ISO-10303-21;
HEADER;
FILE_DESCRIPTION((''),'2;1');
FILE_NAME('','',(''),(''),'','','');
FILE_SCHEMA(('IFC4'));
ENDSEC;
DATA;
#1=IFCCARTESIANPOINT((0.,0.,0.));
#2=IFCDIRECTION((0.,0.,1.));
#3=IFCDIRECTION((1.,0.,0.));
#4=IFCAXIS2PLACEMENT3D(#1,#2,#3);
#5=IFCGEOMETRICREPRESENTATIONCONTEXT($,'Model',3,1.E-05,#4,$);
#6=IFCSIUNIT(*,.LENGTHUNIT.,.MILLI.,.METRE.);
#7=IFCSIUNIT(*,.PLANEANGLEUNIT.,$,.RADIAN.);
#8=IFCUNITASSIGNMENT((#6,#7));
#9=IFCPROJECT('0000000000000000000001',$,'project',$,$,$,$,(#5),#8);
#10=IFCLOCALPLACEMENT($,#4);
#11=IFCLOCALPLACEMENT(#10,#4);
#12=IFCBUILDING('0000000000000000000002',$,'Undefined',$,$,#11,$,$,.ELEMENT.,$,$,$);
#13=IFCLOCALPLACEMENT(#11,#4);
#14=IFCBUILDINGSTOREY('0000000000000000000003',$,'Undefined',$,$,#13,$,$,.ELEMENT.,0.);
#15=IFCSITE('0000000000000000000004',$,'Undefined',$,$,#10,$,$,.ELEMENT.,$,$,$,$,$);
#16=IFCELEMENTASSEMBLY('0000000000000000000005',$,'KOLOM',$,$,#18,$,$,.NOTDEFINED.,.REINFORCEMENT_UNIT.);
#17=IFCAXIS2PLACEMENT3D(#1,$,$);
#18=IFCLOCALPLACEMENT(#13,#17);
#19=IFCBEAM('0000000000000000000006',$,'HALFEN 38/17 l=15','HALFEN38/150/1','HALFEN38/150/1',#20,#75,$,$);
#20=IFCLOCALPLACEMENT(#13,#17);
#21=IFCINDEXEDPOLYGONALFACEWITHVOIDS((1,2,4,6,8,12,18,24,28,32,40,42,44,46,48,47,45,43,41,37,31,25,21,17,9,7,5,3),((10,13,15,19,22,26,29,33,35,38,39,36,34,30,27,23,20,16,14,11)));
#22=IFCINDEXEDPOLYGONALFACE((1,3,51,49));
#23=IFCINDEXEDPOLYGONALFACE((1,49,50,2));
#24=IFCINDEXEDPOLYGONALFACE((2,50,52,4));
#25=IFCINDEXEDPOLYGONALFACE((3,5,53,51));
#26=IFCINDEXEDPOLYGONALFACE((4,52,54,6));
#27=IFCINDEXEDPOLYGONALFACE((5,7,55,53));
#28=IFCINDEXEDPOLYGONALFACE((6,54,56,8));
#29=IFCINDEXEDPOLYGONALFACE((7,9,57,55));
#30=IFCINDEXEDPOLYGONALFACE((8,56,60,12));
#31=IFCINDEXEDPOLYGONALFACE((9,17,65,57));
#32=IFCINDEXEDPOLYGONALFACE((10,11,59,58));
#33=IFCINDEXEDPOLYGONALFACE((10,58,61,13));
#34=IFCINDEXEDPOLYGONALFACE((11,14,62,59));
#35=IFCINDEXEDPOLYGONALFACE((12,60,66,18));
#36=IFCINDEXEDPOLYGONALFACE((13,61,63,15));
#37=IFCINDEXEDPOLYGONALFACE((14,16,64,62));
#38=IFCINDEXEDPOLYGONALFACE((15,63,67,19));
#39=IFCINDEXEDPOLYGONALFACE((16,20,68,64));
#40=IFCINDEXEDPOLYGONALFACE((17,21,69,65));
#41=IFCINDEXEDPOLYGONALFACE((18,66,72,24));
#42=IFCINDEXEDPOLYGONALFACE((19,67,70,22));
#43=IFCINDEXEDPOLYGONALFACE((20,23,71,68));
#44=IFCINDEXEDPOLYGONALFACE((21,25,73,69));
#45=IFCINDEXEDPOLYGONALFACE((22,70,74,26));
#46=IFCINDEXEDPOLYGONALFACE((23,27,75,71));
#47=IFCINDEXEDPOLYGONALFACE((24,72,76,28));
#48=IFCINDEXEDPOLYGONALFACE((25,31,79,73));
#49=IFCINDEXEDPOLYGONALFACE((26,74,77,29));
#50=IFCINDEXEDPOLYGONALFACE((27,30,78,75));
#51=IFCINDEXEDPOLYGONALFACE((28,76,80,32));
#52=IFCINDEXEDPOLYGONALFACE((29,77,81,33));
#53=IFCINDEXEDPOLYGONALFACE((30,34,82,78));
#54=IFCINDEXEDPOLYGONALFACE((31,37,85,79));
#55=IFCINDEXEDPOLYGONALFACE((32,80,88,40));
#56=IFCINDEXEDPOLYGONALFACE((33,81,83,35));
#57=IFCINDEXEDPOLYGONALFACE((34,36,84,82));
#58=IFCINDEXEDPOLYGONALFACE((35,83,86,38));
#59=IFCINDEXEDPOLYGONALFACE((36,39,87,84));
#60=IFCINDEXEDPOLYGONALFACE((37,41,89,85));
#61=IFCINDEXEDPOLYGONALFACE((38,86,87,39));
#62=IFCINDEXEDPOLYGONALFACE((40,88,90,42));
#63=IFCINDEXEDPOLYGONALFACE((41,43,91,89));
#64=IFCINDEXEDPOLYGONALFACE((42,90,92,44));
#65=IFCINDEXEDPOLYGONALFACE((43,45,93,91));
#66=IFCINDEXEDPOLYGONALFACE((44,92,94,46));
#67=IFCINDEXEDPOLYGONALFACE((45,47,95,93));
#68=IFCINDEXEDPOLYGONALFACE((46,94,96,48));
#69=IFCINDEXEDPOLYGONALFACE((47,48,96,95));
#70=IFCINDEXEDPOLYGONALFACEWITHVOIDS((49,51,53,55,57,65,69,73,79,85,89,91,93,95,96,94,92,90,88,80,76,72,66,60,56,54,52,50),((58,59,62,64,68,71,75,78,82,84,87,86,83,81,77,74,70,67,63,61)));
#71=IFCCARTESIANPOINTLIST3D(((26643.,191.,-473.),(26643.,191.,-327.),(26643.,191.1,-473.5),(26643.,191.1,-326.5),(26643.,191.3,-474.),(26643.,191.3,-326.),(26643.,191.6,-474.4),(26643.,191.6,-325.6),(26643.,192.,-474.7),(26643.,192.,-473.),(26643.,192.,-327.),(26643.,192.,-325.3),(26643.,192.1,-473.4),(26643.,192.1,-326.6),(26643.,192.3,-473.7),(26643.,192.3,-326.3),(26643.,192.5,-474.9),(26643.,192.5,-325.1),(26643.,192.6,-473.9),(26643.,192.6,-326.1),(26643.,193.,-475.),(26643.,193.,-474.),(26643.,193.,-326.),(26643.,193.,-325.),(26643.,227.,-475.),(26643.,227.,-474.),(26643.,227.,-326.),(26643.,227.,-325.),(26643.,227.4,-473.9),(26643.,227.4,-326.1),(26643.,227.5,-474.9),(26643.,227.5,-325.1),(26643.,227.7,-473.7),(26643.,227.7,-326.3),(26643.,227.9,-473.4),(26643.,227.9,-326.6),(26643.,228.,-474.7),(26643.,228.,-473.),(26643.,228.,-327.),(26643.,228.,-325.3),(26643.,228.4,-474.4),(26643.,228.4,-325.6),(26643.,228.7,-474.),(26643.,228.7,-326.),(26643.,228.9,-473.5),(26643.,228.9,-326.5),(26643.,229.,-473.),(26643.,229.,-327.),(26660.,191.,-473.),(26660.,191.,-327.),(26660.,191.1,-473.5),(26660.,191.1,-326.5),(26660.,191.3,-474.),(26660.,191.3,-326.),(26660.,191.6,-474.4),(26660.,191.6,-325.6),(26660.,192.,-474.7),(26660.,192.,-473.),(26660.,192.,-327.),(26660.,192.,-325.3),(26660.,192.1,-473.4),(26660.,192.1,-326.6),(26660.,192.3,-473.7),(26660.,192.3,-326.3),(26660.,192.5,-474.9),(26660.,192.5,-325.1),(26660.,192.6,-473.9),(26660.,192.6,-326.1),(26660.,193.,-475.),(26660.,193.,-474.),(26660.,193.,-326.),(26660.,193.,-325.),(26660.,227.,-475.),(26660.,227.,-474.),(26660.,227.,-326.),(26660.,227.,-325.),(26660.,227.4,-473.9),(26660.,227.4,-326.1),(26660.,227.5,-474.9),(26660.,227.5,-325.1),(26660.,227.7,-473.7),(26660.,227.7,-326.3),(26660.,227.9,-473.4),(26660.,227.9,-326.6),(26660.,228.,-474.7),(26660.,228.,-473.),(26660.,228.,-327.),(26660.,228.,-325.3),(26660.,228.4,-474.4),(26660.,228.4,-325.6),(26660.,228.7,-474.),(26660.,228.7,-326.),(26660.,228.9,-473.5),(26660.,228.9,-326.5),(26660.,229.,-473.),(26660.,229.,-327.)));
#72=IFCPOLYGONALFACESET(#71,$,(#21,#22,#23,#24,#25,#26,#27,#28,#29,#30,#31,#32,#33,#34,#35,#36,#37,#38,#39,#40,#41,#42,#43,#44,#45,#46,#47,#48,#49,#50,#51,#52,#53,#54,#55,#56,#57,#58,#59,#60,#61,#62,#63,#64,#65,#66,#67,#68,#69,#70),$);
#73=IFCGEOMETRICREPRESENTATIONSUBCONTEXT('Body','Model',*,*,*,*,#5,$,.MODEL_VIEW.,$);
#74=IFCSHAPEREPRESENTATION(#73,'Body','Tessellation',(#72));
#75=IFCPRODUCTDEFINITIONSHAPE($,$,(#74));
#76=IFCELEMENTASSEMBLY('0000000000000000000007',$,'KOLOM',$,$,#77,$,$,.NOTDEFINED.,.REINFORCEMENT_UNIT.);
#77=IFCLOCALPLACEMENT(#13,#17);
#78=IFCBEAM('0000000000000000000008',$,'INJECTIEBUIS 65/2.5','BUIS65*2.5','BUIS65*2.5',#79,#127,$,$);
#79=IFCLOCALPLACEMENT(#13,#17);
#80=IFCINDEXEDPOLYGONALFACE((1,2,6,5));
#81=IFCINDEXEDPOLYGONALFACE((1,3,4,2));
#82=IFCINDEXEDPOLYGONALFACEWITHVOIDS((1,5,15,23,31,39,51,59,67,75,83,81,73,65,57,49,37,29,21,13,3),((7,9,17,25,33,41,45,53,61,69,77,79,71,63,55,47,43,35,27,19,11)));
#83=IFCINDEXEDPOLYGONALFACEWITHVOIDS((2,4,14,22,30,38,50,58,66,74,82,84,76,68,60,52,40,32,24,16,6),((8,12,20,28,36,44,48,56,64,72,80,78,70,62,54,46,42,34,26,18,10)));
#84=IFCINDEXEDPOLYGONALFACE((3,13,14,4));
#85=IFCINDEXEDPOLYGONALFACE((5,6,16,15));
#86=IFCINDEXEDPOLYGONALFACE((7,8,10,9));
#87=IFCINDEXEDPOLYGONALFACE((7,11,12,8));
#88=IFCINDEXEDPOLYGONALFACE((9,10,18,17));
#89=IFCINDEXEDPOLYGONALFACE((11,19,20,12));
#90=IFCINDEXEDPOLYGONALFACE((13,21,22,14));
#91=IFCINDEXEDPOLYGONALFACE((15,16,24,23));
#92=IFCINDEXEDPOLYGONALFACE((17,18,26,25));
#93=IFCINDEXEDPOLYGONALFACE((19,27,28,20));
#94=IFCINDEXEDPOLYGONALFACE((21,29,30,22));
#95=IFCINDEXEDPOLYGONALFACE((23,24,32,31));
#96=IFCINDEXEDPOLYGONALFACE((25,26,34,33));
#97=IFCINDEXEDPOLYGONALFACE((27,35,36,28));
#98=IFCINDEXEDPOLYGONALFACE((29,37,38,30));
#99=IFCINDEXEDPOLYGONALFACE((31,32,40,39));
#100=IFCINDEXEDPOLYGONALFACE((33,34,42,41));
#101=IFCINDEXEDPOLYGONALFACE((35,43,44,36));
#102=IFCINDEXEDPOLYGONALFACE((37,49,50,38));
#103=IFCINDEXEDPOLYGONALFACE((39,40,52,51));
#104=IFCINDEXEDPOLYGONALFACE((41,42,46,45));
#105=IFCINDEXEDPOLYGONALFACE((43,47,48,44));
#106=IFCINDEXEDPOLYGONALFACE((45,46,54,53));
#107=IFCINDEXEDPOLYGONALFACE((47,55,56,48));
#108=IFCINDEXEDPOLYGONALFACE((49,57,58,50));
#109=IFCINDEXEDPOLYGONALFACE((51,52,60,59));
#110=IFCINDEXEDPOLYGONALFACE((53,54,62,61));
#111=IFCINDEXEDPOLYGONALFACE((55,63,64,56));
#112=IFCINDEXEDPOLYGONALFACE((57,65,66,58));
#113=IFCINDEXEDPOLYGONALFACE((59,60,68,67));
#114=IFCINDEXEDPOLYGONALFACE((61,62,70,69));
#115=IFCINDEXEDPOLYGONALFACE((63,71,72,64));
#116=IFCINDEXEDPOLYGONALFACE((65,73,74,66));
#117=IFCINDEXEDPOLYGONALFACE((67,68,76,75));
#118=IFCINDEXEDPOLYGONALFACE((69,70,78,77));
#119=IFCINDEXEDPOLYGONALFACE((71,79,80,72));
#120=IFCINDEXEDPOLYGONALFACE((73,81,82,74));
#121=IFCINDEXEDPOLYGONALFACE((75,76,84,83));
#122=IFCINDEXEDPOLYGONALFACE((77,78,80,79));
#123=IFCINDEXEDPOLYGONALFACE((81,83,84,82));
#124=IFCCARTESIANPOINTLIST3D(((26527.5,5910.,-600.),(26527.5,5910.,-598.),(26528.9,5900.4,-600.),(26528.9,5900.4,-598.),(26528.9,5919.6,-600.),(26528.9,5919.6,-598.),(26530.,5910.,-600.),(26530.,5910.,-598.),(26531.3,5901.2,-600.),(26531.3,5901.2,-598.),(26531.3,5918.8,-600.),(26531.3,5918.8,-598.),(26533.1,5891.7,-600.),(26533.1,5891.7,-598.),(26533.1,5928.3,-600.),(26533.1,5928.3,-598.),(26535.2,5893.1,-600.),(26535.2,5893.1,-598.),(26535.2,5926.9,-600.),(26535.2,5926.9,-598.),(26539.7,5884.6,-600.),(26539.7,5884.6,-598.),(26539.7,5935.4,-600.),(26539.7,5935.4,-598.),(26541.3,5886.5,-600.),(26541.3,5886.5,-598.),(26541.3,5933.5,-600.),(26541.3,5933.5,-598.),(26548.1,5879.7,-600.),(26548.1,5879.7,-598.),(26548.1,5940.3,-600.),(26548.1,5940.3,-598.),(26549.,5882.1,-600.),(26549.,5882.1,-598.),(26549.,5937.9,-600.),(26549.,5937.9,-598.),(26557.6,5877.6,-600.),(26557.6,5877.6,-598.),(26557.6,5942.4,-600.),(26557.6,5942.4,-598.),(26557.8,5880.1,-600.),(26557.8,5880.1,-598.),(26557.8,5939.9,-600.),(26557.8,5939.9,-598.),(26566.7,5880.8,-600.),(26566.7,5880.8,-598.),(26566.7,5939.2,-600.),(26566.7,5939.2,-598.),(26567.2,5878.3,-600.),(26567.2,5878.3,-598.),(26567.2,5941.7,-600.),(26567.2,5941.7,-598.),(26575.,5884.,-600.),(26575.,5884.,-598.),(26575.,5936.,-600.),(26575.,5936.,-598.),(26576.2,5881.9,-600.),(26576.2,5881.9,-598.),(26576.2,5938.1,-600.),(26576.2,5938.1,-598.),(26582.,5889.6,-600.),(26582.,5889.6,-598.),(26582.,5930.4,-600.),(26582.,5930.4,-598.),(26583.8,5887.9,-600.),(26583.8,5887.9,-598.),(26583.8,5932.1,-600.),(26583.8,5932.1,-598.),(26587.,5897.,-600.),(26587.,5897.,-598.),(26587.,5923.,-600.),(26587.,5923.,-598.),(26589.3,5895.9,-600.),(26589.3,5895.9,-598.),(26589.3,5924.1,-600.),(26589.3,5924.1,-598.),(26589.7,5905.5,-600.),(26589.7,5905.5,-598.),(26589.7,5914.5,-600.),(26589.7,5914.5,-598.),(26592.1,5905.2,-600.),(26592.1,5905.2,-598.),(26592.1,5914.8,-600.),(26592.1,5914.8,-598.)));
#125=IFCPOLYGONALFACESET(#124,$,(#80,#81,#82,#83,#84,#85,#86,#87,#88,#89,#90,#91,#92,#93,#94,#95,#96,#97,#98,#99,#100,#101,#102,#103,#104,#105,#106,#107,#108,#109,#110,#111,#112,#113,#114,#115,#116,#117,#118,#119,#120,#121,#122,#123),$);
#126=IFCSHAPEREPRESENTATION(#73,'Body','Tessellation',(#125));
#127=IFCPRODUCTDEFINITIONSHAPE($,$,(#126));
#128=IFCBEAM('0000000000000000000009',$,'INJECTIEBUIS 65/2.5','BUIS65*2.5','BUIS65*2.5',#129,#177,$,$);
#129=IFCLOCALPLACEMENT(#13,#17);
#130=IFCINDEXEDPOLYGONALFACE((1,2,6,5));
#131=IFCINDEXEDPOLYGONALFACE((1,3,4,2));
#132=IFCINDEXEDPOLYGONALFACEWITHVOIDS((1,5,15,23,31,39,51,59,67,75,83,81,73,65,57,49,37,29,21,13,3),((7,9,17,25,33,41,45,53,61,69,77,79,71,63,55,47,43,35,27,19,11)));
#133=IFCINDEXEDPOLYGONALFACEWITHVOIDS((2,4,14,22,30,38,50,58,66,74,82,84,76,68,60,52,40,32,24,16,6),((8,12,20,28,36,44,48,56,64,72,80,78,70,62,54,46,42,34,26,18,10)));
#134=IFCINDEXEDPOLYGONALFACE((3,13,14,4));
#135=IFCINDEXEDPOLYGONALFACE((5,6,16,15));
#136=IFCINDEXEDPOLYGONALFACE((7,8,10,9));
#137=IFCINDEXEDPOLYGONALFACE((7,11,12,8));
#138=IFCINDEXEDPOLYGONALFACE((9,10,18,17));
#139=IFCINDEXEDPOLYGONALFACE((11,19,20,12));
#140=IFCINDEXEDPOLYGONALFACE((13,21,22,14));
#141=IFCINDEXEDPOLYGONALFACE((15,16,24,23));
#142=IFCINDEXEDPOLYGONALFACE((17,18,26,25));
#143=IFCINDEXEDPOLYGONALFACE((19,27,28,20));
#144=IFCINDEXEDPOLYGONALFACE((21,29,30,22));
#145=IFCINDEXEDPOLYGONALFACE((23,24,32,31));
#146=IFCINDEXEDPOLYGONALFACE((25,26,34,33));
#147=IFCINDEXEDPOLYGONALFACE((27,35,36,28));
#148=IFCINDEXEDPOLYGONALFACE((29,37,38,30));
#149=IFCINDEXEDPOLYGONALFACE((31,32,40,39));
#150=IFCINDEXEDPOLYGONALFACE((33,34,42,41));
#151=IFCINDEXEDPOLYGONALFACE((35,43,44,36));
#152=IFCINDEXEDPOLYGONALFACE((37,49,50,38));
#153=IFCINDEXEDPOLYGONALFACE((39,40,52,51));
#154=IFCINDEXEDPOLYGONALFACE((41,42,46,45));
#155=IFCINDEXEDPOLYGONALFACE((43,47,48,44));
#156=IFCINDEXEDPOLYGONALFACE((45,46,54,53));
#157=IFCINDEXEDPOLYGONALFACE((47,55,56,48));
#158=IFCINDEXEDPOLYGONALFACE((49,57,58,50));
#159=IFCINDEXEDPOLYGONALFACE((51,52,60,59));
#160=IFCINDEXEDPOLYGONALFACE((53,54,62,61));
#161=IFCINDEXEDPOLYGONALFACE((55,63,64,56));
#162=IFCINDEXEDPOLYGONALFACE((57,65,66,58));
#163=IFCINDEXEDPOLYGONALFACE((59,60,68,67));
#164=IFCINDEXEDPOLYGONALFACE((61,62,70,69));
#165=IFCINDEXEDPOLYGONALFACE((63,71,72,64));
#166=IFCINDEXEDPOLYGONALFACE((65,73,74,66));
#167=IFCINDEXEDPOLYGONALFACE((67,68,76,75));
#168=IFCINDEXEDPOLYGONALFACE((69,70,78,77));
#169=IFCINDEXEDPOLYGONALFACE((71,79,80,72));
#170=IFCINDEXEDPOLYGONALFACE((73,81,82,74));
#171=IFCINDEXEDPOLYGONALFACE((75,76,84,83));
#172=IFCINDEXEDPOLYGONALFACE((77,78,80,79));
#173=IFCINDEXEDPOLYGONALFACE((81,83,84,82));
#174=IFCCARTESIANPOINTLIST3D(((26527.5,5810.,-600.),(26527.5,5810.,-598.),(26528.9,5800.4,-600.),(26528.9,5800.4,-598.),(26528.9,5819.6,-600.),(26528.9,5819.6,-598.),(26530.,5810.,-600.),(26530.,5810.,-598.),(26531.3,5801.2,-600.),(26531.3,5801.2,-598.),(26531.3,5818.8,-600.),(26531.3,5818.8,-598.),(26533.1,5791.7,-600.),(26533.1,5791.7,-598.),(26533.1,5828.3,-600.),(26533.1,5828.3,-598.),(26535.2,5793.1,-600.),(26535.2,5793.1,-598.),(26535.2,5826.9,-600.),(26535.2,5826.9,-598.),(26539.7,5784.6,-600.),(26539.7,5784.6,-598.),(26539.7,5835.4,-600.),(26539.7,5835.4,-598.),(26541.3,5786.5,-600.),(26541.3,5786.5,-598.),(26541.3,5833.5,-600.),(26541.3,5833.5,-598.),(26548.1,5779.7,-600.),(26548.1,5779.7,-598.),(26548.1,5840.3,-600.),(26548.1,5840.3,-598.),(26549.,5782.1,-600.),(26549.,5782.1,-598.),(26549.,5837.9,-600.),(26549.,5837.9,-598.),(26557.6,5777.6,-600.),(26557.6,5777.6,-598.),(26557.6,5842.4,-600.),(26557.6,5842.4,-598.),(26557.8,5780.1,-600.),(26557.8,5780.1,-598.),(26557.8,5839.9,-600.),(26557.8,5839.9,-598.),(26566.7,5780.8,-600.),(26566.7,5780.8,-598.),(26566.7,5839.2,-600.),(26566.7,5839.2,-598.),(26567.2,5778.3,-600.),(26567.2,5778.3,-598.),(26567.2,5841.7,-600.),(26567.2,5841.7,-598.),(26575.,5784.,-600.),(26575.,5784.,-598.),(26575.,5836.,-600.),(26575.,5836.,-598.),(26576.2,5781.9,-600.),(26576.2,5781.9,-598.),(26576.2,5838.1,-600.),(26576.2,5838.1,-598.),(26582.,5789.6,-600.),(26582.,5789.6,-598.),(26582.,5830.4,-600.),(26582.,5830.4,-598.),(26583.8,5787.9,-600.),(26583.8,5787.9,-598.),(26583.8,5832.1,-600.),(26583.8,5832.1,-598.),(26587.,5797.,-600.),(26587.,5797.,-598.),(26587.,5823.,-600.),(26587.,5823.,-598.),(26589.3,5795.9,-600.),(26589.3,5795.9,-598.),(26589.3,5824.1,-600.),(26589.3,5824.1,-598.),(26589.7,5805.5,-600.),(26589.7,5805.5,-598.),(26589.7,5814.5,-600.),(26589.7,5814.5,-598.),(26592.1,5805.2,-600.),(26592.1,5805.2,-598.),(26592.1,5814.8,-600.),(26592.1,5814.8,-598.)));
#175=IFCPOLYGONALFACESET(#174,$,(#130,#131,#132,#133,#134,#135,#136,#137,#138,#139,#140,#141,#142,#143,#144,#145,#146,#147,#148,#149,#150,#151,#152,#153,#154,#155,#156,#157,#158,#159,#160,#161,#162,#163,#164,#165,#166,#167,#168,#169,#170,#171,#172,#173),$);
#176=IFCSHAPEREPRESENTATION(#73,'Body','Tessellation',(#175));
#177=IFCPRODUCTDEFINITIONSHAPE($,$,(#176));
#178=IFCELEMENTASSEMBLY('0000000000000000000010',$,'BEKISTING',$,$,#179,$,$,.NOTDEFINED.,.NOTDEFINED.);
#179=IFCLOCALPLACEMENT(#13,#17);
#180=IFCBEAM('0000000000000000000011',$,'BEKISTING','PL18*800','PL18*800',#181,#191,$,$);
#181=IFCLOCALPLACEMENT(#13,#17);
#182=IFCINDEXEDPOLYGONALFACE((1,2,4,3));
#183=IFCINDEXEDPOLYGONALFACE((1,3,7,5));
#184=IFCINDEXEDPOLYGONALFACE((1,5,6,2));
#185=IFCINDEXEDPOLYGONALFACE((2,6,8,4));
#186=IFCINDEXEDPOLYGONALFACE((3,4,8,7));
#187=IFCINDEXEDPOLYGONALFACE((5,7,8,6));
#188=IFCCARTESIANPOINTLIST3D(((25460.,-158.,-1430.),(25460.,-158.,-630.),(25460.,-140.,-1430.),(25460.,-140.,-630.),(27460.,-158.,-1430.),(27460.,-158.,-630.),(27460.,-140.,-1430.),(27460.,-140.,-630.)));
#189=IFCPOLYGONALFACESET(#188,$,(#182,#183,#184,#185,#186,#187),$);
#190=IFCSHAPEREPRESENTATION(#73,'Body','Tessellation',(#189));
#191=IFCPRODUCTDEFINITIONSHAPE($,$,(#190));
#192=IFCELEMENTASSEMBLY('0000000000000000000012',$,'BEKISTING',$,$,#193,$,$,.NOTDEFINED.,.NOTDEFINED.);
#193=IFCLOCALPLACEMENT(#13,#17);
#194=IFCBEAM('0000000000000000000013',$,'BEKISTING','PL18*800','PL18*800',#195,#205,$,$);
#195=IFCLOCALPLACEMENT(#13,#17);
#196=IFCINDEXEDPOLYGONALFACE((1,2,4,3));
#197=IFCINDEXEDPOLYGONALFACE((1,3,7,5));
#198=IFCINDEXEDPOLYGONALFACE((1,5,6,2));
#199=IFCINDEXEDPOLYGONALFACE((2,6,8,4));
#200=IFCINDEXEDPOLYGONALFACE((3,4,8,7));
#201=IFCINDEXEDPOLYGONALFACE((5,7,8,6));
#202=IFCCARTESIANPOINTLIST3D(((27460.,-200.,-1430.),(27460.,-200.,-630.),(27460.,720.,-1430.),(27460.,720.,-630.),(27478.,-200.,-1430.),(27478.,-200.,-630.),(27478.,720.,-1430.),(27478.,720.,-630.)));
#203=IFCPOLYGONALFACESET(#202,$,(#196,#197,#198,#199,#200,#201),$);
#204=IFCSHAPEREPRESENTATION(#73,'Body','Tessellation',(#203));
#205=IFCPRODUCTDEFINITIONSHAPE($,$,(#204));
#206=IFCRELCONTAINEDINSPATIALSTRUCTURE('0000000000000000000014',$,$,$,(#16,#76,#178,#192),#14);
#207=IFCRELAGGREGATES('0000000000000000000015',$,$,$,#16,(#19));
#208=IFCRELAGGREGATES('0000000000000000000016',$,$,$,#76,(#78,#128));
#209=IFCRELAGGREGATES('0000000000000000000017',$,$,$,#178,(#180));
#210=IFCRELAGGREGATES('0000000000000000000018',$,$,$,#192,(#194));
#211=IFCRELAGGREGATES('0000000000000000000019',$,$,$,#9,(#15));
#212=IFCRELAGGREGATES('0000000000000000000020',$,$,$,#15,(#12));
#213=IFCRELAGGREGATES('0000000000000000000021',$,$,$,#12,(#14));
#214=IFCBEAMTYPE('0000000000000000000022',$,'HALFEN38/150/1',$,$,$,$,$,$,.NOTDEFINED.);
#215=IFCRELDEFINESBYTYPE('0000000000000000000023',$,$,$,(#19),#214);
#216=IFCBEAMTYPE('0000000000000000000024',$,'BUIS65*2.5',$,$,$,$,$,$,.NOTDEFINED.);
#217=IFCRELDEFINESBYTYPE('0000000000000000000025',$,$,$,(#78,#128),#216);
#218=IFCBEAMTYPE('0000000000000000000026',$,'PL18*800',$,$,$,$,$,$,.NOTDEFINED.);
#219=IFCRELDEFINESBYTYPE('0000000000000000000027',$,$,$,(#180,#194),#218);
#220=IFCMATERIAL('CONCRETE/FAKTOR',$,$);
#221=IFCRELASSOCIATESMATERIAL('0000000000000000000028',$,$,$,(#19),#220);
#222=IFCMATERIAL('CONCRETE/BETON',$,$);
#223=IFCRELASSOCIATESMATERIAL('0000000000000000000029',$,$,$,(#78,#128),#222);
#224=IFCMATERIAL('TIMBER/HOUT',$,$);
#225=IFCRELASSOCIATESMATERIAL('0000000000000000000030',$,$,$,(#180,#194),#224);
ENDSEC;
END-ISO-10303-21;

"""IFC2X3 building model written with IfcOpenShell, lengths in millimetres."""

from ifc_helpers import new_model, si_unit, frame, frame_2d, origin_with_axes, place, context, subcontext, project, spatial, rectangle, hollow_rectangle, hollow_circle, extrude, material, type_object, element, aggregate, save


model = new_model("IFC2X3")

# Units and contexts
model_context = context("Model", 3, precision=1e-05, world=origin_with_axes())
body_context = subcontext(model_context, "Body", "Model", "MODEL_VIEW")
ifc_project = project(units=[si_unit("LENGTHUNIT", "METRE", prefix="MILLI"), si_unit("PLANEANGLEUNIT", "RADIAN")], contexts=[model_context])

# Site, building, storey
site_placement = place(None, origin_with_axes())
site = spatial("IfcSite", under=ifc_project, at=site_placement, Name="Undefined", CompositionType="ELEMENT")
building_placement = place(site_placement, origin_with_axes())
building = spatial("IfcBuilding", under=site, at=building_placement, Name="Undefined", CompositionType="ELEMENT")
storey_placement = place(building_placement, origin_with_axes())
storey = spatial("IfcBuildingStorey", under=building, at=storey_placement, Name="Undefined", CompositionType="ELEMENT", Elevation=0.0)

# Shared definitions
ifc_material_1 = material(Name="CONCRETE/BETON")

# Shared definitions
ifc_material_2 = material(Name="CONCRETE/FAKTOR")

# Element assembly
assembly_1_placement = place(storey_placement, origin_with_axes())
assembly_1 = element("IfcElementAssembly", 1, at=assembly_1_placement, inside=storey, Name="KOLOM", AssemblyPlace="NOTDEFINED", PredefinedType="REINFORCEMENT_UNIT")

# Beam
beam_type_1 = type_object("IfcBeamType", Name="HALFEN38/150/1", PredefinedType="NOTDEFINED")
beam_1_placement = place(assembly_1_placement, frame((26660.0, 210.0, -400.0), z_axis=(0.0, 1.0, 0.0), x_axis=(-1.0, 0.0, 0.0)))
beam_1 = element("IfcBeam", 2, at=beam_1_placement, type_object=beam_type_1, material=ifc_material_2, Name="HALFEN 38/17 l=15", Description="HALFEN38/150/1", ObjectType="HALFEN38/150/1", context=body_context, shape_type="SweptSolid", body=[
    extrude(hollow_rectangle(XDim=150.0, YDim=38.0, WallThickness=1.0, InnerFilletRadius=1.0, OuterFilletRadius=2.0, at=frame_2d((0.0, 0.0), x_axis=(1.0, 0.0))), frame((17.0, 0.0, 0.0), z_axis=(-1.0, 0.0, 0.0), x_axis=(0.0, -1.0, 0.0)), (0.0, 0.0, 1.0), 17.0),
])
aggregate(assembly_1, [beam_1])

# Element assembly, beams
assembly_2_placement = place(storey_placement, origin_with_axes())
assembly_2 = element("IfcElementAssembly", 3, at=assembly_2_placement, inside=storey, Name="KOLOM", AssemblyPlace="NOTDEFINED", PredefinedType="REINFORCEMENT_UNIT")
beam_type_2 = type_object("IfcBeamType", Name="BUIS65*2.5", PredefinedType="NOTDEFINED")
beam_2_placement = place(assembly_2_placement, frame((26560.0, 5910.0, -600.0), z_axis=(0.0, 1.0, 0.0), x_axis=(0.0, 0.0, 1.0)))
beam_2 = element("IfcBeam", 4, at=beam_2_placement, type_object=beam_type_2, material=ifc_material_1, Name="INJECTIEBUIS 65/2.5", Description="BUIS65*2.5", ObjectType="BUIS65*2.5", context=body_context, shape_type="SweptSolid", body=[
    extrude(hollow_circle(Radius=32.5, WallThickness=2.5, at=frame_2d((0.0, 0.0), x_axis=(1.0, 0.0))), frame((2.0, 0.0, 0.0), z_axis=(-1.0, 0.0, 0.0), x_axis=(0.0, -1.0, 0.0)), (0.0, 0.0, 1.0), 2.0),
])
beam_3_placement = place(assembly_2_placement, frame((26560.0, 5810.0, -600.0), z_axis=(0.0, 1.0, 0.0), x_axis=(0.0, 0.0, 1.0)))
beam_3 = element("IfcBeam", 5, at=beam_3_placement, type_object=beam_type_2, material=ifc_material_1, Name="INJECTIEBUIS 65/2.5", Description="BUIS65*2.5", ObjectType="BUIS65*2.5", context=body_context, shape_type="SweptSolid", body=[
    extrude(hollow_circle(Radius=32.5, WallThickness=2.5, at=frame_2d((0.0, 0.0), x_axis=(1.0, 0.0))), frame((2.0, 0.0, 0.0), z_axis=(-1.0, 0.0, 0.0), x_axis=(0.0, -1.0, 0.0)), (0.0, 0.0, 1.0), 2.0),
])
aggregate(assembly_2, [beam_2, beam_3])

# Element assemblies, beams
assembly_3_placement = place(storey_placement, origin_with_axes())
assembly_3 = element("IfcElementAssembly", 6, at=assembly_3_placement, inside=storey, Name="BEKISTING", AssemblyPlace="NOTDEFINED", PredefinedType="NOTDEFINED")
ifc_material_3 = material(Name="TIMBER/HOUT")
beam_type_3 = type_object("IfcBeamType", Name="PL18*800", PredefinedType="NOTDEFINED")
beam_4_placement = place(assembly_3_placement, frame((27460.0, -149.0, -1030.0), z_axis=(0.0, 0.0, -1.0), x_axis=(-1.0, 0.0, 0.0)))
beam_4 = element("IfcBeam", 7, at=beam_4_placement, type_object=beam_type_3, material=ifc_material_3, Name="BEKISTING", Description="PL18*800", ObjectType="PL18*800", context=body_context, shape_type="SweptSolid", body=[
    extrude(rectangle(XDim=18.0, YDim=800.0, at=frame_2d((0.0, 0.0), x_axis=(1.0, 0.0))), frame((2000.0, 0.0, 0.0), z_axis=(-1.0, 0.0, 0.0), x_axis=(0.0, -1.0, 0.0)), (0.0, 0.0, 1.0), 2000.0),
])
aggregate(assembly_3, [beam_4])
assembly_4_placement = place(storey_placement, origin_with_axes())
assembly_4 = element("IfcElementAssembly", 8, at=assembly_4_placement, inside=storey, Name="BEKISTING", AssemblyPlace="NOTDEFINED", PredefinedType="NOTDEFINED")
beam_5_placement = place(assembly_4_placement, frame((27469.0, 720.0, -1030.0), z_axis=(0.0, 0.0, 1.0), x_axis=(0.0, -1.0, 0.0)))
beam_5 = element("IfcBeam", 9, at=beam_5_placement, type_object=beam_type_3, material=ifc_material_3, Name="BEKISTING", Description="PL18*800", ObjectType="PL18*800", context=body_context, shape_type="SweptSolid", body=[
    extrude(rectangle(XDim=18.0, YDim=800.0, at=frame_2d((0.0, 0.0), x_axis=(1.0, 0.0))), frame((920.0, 0.0, 0.0), z_axis=(-1.0, 0.0, 0.0), x_axis=(0.0, -1.0, 0.0)), (0.0, 0.0, 1.0), 920.0),
])

aggregate(assembly_4, [beam_5])

save(model, "model.ifc")
